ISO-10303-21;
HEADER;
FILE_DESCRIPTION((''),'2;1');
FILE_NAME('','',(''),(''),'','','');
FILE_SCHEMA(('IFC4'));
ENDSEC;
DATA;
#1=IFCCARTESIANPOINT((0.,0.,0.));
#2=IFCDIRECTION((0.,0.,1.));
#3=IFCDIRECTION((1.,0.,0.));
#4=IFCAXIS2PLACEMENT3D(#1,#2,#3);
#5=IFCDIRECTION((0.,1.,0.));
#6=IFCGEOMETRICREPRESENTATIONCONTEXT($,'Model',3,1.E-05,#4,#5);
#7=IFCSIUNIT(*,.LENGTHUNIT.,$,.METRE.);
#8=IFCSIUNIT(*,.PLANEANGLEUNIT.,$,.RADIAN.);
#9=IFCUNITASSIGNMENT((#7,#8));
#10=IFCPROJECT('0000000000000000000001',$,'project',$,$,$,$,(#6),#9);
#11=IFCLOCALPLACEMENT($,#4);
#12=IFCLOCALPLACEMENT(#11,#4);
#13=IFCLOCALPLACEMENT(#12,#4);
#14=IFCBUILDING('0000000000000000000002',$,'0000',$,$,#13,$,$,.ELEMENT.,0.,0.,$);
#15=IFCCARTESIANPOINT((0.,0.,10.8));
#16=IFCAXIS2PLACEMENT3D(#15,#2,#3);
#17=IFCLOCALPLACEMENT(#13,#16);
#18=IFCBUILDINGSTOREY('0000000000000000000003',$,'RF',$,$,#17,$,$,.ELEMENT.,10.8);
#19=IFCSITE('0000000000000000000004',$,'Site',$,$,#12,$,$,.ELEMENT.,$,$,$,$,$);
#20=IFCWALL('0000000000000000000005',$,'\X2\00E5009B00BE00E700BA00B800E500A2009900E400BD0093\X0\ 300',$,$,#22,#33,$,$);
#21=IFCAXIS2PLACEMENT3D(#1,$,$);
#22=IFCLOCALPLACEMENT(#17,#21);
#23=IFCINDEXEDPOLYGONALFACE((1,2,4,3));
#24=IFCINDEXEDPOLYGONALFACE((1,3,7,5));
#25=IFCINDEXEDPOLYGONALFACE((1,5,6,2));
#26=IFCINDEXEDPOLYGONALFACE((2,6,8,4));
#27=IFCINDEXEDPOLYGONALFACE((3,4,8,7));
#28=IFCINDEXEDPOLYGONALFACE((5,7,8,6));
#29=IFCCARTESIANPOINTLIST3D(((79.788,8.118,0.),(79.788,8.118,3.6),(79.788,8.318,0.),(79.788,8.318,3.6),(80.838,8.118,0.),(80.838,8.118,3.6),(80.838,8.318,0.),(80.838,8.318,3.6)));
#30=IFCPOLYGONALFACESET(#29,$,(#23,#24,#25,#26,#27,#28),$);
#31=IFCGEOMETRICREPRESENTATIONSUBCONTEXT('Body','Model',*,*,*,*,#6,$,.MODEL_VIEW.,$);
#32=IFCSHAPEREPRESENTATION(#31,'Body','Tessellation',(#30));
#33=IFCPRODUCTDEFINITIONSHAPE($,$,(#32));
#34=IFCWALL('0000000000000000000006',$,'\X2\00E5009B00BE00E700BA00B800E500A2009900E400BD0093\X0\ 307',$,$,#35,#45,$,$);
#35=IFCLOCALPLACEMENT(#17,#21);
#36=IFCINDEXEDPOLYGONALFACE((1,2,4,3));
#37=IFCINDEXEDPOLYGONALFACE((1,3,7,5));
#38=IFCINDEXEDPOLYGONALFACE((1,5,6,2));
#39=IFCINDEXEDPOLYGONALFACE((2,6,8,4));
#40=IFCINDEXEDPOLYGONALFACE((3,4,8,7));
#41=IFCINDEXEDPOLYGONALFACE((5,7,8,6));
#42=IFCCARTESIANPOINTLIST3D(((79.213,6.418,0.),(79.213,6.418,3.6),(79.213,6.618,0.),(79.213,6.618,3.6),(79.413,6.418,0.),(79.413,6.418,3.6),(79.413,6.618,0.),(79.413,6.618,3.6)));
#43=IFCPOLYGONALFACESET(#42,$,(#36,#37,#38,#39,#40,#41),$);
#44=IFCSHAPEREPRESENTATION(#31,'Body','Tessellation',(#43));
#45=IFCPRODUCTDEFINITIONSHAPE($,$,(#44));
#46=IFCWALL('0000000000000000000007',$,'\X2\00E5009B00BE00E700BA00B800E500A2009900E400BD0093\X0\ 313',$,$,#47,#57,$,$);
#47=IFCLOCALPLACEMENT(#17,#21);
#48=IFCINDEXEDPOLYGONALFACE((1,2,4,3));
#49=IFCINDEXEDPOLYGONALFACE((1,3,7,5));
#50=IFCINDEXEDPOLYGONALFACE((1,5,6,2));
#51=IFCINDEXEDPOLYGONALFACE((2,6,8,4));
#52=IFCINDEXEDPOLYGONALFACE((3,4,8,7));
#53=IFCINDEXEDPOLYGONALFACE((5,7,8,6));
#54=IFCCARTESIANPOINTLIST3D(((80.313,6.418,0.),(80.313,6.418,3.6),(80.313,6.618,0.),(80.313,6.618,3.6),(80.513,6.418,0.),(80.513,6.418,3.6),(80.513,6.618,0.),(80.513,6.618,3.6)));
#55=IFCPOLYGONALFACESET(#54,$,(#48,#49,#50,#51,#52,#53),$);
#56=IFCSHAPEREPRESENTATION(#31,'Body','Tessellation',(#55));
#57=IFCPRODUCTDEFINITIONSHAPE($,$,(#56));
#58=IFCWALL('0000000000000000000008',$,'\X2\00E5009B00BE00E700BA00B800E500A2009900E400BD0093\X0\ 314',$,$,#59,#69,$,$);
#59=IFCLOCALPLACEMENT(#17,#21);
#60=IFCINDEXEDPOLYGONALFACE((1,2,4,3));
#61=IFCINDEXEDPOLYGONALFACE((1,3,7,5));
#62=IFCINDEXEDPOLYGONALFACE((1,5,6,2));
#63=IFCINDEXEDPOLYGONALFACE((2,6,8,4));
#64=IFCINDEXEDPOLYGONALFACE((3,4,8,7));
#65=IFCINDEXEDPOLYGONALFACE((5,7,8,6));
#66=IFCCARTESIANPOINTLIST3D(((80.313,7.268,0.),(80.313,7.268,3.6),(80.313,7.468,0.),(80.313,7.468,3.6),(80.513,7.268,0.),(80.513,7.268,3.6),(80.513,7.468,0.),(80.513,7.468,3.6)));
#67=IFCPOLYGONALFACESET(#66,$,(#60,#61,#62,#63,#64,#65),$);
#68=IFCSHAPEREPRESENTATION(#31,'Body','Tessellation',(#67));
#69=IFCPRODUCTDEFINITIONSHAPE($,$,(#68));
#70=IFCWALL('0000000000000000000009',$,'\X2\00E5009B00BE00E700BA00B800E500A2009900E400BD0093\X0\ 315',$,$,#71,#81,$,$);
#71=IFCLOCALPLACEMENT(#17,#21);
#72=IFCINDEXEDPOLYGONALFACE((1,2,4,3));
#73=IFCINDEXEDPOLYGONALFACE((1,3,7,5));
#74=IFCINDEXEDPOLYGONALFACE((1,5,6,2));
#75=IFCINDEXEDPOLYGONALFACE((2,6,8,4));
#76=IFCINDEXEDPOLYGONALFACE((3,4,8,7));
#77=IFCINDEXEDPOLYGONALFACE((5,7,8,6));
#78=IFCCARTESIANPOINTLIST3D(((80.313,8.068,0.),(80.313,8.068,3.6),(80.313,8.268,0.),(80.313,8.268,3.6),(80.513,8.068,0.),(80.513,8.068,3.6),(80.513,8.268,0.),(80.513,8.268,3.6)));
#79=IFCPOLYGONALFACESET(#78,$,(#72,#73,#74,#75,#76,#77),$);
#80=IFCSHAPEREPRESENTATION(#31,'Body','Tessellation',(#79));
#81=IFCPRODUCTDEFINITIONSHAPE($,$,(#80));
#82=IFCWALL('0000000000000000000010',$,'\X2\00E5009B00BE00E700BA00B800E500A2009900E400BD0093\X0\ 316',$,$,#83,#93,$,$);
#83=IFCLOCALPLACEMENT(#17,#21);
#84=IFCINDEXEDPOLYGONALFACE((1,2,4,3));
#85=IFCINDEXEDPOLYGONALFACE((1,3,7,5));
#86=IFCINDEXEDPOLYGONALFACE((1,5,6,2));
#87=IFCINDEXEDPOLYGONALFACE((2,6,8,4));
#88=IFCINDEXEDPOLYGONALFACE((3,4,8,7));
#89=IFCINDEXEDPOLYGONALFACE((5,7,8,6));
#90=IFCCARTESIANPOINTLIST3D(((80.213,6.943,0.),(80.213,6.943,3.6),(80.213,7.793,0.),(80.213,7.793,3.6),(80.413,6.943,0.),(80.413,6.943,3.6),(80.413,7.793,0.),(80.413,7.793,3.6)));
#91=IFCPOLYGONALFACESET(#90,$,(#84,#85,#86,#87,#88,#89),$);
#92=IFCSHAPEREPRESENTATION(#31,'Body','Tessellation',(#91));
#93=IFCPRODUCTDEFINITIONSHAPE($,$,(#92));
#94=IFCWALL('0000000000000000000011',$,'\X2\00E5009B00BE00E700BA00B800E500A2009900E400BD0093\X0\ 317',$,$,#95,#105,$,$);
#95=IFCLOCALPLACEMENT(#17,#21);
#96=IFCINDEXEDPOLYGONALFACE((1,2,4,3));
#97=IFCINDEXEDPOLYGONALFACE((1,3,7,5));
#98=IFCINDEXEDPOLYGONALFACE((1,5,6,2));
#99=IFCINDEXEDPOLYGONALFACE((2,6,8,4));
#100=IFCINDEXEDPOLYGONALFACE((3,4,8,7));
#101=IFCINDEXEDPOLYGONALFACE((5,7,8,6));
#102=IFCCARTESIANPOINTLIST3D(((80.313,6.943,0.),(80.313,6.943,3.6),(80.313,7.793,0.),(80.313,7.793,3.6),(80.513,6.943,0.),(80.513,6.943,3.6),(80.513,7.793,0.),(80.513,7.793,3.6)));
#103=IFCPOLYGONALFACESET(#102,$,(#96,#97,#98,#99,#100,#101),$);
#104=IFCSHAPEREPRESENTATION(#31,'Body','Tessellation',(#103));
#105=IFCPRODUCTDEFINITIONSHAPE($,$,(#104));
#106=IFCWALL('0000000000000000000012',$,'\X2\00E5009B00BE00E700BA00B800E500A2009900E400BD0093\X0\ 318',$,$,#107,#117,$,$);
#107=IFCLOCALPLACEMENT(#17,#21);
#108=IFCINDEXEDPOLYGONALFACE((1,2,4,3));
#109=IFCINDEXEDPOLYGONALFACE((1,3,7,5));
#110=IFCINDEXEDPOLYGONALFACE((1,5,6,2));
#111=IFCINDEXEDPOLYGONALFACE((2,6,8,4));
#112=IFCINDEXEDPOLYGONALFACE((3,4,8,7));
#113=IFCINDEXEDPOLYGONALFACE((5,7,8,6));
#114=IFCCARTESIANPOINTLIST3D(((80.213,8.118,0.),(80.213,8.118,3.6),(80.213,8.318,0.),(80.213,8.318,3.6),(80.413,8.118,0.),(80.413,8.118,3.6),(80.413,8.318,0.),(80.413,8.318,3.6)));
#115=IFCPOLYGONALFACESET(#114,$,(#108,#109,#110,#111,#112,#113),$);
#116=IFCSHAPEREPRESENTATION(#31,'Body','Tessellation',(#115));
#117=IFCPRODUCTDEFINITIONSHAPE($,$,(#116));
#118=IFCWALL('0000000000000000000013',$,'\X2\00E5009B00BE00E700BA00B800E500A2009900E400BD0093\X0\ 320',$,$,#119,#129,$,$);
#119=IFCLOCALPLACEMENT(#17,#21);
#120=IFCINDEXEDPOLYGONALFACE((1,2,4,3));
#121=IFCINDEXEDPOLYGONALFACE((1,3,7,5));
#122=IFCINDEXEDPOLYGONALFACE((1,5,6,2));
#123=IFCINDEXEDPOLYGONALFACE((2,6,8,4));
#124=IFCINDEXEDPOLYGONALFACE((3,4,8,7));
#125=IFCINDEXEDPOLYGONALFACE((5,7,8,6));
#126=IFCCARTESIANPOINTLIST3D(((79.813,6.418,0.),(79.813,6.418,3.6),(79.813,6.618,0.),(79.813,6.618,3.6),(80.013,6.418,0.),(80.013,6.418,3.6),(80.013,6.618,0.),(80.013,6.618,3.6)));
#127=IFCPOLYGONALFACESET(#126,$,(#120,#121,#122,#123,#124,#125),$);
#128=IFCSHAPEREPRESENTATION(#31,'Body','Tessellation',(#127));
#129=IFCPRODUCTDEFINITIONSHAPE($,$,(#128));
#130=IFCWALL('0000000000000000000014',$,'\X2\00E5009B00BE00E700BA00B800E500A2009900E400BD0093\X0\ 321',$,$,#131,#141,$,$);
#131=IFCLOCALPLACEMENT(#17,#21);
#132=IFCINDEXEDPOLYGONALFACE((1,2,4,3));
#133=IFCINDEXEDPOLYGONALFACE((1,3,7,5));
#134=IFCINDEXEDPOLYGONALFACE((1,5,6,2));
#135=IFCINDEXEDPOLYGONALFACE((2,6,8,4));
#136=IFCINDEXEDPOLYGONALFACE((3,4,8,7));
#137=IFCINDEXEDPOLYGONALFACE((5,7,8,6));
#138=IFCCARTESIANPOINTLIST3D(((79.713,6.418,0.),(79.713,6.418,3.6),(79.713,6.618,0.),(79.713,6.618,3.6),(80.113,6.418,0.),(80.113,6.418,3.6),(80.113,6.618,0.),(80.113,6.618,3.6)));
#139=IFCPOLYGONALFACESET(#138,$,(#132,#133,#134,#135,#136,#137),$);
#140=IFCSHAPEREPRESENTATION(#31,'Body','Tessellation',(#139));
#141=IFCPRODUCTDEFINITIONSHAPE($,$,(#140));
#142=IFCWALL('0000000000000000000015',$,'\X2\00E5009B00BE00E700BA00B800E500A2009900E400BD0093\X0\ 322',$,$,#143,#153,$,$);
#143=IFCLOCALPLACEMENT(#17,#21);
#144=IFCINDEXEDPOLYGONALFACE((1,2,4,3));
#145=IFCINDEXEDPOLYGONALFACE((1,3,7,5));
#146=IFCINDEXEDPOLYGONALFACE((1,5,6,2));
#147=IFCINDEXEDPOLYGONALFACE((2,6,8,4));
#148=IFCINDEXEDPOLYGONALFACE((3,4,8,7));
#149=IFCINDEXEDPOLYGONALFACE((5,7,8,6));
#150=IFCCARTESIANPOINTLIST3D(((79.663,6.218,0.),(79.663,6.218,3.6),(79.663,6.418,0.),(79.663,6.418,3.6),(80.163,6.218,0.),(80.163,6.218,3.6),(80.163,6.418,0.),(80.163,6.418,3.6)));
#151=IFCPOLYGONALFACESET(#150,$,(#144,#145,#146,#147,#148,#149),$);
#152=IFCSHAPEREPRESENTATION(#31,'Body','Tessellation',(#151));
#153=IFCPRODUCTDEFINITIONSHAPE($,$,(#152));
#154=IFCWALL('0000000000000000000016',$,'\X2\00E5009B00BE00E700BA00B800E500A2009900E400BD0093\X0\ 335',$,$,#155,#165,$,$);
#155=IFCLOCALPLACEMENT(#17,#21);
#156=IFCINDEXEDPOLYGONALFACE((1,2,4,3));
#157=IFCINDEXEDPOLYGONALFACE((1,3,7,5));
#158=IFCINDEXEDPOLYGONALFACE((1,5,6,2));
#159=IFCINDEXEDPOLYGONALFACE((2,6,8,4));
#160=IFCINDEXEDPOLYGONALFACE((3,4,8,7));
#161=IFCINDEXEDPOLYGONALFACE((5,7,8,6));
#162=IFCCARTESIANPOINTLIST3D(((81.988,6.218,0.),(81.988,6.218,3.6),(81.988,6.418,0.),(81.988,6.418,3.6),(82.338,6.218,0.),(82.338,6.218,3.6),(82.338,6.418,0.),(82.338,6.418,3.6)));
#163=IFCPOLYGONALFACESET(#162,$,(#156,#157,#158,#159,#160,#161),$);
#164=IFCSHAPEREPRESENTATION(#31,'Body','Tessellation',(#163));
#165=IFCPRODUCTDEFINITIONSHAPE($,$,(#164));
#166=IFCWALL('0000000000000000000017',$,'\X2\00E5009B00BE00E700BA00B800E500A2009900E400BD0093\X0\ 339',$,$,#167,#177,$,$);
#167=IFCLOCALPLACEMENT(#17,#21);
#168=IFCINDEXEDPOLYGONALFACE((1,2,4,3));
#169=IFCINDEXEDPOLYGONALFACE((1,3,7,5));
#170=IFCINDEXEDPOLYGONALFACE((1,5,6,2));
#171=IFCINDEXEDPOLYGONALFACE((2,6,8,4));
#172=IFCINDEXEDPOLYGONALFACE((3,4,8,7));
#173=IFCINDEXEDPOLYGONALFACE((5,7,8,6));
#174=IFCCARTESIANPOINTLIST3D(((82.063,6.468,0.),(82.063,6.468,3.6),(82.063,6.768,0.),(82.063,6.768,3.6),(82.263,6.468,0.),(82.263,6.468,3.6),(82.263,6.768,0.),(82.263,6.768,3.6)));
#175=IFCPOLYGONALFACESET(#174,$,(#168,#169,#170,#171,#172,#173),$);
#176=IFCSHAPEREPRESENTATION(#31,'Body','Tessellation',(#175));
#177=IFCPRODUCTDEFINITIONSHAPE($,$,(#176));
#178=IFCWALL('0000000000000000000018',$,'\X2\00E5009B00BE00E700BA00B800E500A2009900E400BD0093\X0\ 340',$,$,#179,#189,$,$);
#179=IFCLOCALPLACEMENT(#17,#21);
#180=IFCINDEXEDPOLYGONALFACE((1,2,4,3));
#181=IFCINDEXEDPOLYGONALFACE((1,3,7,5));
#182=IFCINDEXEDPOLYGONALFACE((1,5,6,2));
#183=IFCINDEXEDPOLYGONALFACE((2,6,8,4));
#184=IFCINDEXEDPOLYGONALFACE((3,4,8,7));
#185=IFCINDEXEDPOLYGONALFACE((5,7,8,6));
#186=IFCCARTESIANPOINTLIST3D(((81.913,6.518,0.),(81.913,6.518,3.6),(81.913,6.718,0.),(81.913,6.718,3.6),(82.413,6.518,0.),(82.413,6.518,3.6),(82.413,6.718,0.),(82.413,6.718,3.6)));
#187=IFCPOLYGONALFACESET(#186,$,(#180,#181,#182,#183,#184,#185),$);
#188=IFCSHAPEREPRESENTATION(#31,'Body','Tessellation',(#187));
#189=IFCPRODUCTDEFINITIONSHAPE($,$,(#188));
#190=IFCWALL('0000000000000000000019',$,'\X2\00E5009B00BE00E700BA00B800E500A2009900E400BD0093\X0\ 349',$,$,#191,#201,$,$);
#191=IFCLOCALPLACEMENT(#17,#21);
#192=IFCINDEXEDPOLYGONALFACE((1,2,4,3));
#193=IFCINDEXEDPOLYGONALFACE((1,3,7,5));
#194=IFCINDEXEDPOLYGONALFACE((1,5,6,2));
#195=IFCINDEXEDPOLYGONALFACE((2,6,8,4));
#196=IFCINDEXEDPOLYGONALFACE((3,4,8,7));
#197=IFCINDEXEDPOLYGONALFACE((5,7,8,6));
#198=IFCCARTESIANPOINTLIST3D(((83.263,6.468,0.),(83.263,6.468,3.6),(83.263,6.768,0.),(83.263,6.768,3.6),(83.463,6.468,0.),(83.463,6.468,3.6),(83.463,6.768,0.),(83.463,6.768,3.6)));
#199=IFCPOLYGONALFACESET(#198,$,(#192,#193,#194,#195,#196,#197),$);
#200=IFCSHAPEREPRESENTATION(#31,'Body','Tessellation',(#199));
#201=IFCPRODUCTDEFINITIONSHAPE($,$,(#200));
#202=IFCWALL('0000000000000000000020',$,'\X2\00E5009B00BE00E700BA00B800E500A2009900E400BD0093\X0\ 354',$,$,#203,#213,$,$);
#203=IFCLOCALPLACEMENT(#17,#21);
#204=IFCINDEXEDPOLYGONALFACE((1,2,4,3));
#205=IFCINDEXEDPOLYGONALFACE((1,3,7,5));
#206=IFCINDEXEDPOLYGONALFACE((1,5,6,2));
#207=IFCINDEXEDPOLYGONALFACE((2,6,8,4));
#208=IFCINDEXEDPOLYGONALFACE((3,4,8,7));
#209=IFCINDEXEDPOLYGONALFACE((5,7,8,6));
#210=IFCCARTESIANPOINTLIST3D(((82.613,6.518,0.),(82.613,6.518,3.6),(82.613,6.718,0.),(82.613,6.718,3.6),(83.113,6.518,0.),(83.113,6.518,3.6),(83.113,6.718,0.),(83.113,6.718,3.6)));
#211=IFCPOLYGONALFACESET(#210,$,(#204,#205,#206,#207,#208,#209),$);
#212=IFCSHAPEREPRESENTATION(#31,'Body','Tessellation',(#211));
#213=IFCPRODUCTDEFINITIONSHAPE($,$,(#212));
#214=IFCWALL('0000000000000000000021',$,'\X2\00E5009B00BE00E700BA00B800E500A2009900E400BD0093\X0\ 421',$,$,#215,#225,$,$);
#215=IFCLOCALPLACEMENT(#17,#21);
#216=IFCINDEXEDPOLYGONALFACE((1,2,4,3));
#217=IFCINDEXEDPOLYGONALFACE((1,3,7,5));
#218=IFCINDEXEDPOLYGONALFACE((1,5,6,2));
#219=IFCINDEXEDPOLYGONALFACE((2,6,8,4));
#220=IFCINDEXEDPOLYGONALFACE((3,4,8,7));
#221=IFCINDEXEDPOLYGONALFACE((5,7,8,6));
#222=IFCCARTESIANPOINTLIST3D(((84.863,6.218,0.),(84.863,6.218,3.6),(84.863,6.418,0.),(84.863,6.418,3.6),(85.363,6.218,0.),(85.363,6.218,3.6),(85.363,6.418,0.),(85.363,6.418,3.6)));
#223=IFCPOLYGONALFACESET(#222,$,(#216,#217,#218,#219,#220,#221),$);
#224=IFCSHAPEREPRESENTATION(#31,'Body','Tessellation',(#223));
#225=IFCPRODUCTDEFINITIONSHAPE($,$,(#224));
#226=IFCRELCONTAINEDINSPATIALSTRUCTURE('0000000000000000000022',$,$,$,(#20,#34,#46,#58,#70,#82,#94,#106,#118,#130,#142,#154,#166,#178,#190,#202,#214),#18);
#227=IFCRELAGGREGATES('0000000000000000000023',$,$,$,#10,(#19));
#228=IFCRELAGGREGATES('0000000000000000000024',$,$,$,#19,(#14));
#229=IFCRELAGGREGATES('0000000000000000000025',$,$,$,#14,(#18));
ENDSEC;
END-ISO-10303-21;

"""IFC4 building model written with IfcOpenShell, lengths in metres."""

from ifc_helpers import new_model, si_unit, direction, frame, frame_2d, origin_with_axes, place, context, subcontext, project, spatial, rectangle, extrude, element, save


model = new_model("IFC4")

# Units and contexts
model_context = context("Model", 3, precision=1e-05, world=origin_with_axes(), true_north=direction((0.0, 1.0, 0.0)))
body_context = subcontext(model_context, "Body", "Model", "MODEL_VIEW")
ifc_project = project(units=[si_unit("LENGTHUNIT", "METRE"), si_unit("PLANEANGLEUNIT", "RADIAN")], contexts=[model_context])

# Site, building, storey
placement = place(None, origin_with_axes())
site_placement = place(placement, origin_with_axes())
site = spatial("IfcSite", under=ifc_project, at=site_placement, Name="Site", CompositionType="ELEMENT")
building_placement = place(site_placement, origin_with_axes())
building = spatial("IfcBuilding", under=site, at=building_placement, Name="0000", CompositionType="ELEMENT", ElevationOfRefHeight=0.0, ElevationOfTerrain=0.0)
storey_placement = place(building_placement, frame((0.0, 0.0, 10.8), z_axis=(0.0, 0.0, 1.0), x_axis=(1.0, 0.0, 0.0)))
storey = spatial("IfcBuildingStorey", under=building, at=storey_placement, Name="RF", CompositionType="ELEMENT", Elevation=10.8)

# Walls
wall_1_placement = place(storey_placement, frame((80.313, 8.218, 0.0), z_axis=(0.0, 0.0, 1.0), x_axis=(-1.0, 0.0, 0.0)))
element("IfcWall", 1, at=wall_1_placement, inside=storey, Name="å\u009b¾çº¸å¢\u0099ä½\u0093 300", context=body_context, shape_type="SweptSolid", body=[
    extrude(rectangle(XDim=1.05, YDim=0.2, at=frame_2d((0.0, 0.0), x_axis=(1.0, 0.0, 0.0))), frame((0.0, 0.0, 0.0), z_axis=(0.0, 0.0, 1.0)), (0.0, 0.0, 1.0), 3.6),
])
for number, where, z_axis, x_axis, name in (
    (2, (79.313, 6.518, 0.0), (0.0, 0.0, 1.0), (0.0, -1.0, 0.0), "å\u009b¾çº¸å¢\u0099ä½\u0093 307"),
    (3, (80.413, 6.518, 0.0), (0.0, 0.0, 1.0), (0.0, -1.0, 0.0), "å\u009b¾çº¸å¢\u0099ä½\u0093 313"),
    (4, (80.413, 7.368, 0.0), (0.0, 0.0, 1.0), (-1.0, 0.0, 0.0), "å\u009b¾çº¸å¢\u0099ä½\u0093 314"),
    (5, (80.413, 8.168, 0.0), (0.0, 0.0, 1.0), (-1.0, 0.0, 0.0), "å\u009b¾çº¸å¢\u0099ä½\u0093 315"),
):
    element("IfcWall", number, at=place(storey_placement, frame(where, z_axis=z_axis, x_axis=x_axis)), inside=storey, Name=name, context=body_context, shape_type="SweptSolid", body=[
        extrude(rectangle(XDim=0.2, YDim=0.2, at=frame_2d((0.0, 0.0), x_axis=(1.0, 0.0, 0.0))), frame((0.0, 0.0, 0.0), z_axis=(0.0, 0.0, 1.0)), (0.0, 0.0, 1.0), 3.6),
    ])
for number, where, z_axis, x_axis, name in (
    (6, (80.313, 7.368, 0.0), (0.0, 0.0, 1.0), (0.0, -1.0, 0.0), "å\u009b¾çº¸å¢\u0099ä½\u0093 316"),
    (7, (80.413, 7.368, 0.0), (0.0, 0.0, 1.0), (0.0, -1.0, 0.0), "å\u009b¾çº¸å¢\u0099ä½\u0093 317"),
):
    element("IfcWall", number, at=place(storey_placement, frame(where, z_axis=z_axis, x_axis=x_axis)), inside=storey, Name=name, context=body_context, shape_type="SweptSolid", body=[
        extrude(rectangle(XDim=0.85, YDim=0.2, at=frame_2d((0.0, 0.0), x_axis=(1.0, 0.0, 0.0))), frame((0.0, 0.0, 0.0), z_axis=(0.0, 0.0, 1.0)), (0.0, 0.0, 1.0), 3.6),
    ])
for number, where, z_axis, x_axis, name in (
    (8, (80.313, 8.218, 0.0), (0.0, 0.0, 1.0), (0.0, -1.0, 0.0), "å\u009b¾çº¸å¢\u0099ä½\u0093 318"),
    (9, (79.913, 6.518, 0.0), (0.0, 0.0, 1.0), (0.0, -1.0, 0.0), "å\u009b¾çº¸å¢\u0099ä½\u0093 320"),
):
    element("IfcWall", number, at=place(storey_placement, frame(where, z_axis=z_axis, x_axis=x_axis)), inside=storey, Name=name, context=body_context, shape_type="SweptSolid", body=[
        extrude(rectangle(XDim=0.2, YDim=0.2, at=frame_2d((0.0, 0.0), x_axis=(1.0, 0.0, 0.0))), frame((0.0, 0.0, 0.0), z_axis=(0.0, 0.0, 1.0)), (0.0, 0.0, 1.0), 3.6),
    ])
wall_2_placement = place(storey_placement, frame((79.913, 6.518, 0.0), z_axis=(0.0, 0.0, 1.0), x_axis=(1.0, 0.0, 0.0)))
element("IfcWall", 10, at=wall_2_placement, inside=storey, Name="å\u009b¾çº¸å¢\u0099ä½\u0093 321", context=body_context, shape_type="SweptSolid", body=[
    extrude(rectangle(XDim=0.4, YDim=0.2, at=frame_2d((0.0, 0.0), x_axis=(1.0, 0.0, 0.0))), frame((0.0, 0.0, 0.0), z_axis=(0.0, 0.0, 1.0)), (0.0, 0.0, 1.0), 3.6),
])
wall_3_placement = place(storey_placement, frame((79.913, 6.318, 0.0), z_axis=(0.0, 0.0, 1.0), x_axis=(1.0, 0.0, 0.0)))
element("IfcWall", 11, at=wall_3_placement, inside=storey, Name="å\u009b¾çº¸å¢\u0099ä½\u0093 322", context=body_context, shape_type="SweptSolid", body=[
    extrude(rectangle(XDim=0.5, YDim=0.2, at=frame_2d((0.0, 0.0), x_axis=(1.0, 0.0, 0.0))), frame((0.0, 0.0, 0.0), z_axis=(0.0, 0.0, 1.0)), (0.0, 0.0, 1.0), 3.6),
])
wall_4_placement = place(storey_placement, frame((82.163, 6.318, 0.0), z_axis=(0.0, 0.0, 1.0), x_axis=(1.0, 0.0, 0.0)))
element("IfcWall", 12, at=wall_4_placement, inside=storey, Name="å\u009b¾çº¸å¢\u0099ä½\u0093 335", context=body_context, shape_type="SweptSolid", body=[
    extrude(rectangle(XDim=0.35, YDim=0.2, at=frame_2d((0.0, 0.0), x_axis=(1.0, 0.0, 0.0))), frame((0.0, 0.0, 0.0), z_axis=(0.0, 0.0, 1.0)), (0.0, 0.0, 1.0), 3.6),
])
wall_5_placement = place(storey_placement, frame((82.163, 6.618, 0.0), z_axis=(0.0, 0.0, 1.0), x_axis=(0.0, -1.0, 0.0)))
element("IfcWall", 13, at=wall_5_placement, inside=storey, Name="å\u009b¾çº¸å¢\u0099ä½\u0093 339", context=body_context, shape_type="SweptSolid", body=[
    extrude(rectangle(XDim=0.3, YDim=0.2, at=frame_2d((0.0, 0.0), x_axis=(1.0, 0.0, 0.0))), frame((0.0, 0.0, 0.0), z_axis=(0.0, 0.0, 1.0)), (0.0, 0.0, 1.0), 3.6),
])
wall_6_placement = place(storey_placement, frame((82.163, 6.618, 0.0), z_axis=(0.0, 0.0, 1.0), x_axis=(1.0, 0.0, 0.0)))
element("IfcWall", 14, at=wall_6_placement, inside=storey, Name="å\u009b¾çº¸å¢\u0099ä½\u0093 340", context=body_context, shape_type="SweptSolid", body=[
    extrude(rectangle(XDim=0.5, YDim=0.2, at=frame_2d((0.0, 0.0), x_axis=(1.0, 0.0, 0.0))), frame((0.0, 0.0, 0.0), z_axis=(0.0, 0.0, 1.0)), (0.0, 0.0, 1.0), 3.6),
])
wall_7_placement = place(storey_placement, frame((83.363, 6.618, 0.0), z_axis=(0.0, 0.0, 1.0), x_axis=(0.0, -1.0, 0.0)))
element("IfcWall", 15, at=wall_7_placement, inside=storey, Name="å\u009b¾çº¸å¢\u0099ä½\u0093 349", context=body_context, shape_type="SweptSolid", body=[
    extrude(rectangle(XDim=0.3, YDim=0.2, at=frame_2d((0.0, 0.0), x_axis=(1.0, 0.0, 0.0))), frame((0.0, 0.0, 0.0), z_axis=(0.0, 0.0, 1.0)), (0.0, 0.0, 1.0), 3.6),
])
for number, where, z_axis, x_axis, name in (
    (16, (82.863, 6.618, 0.0), (0.0, 0.0, 1.0), (1.0, 0.0, 0.0), "å\u009b¾çº¸å¢\u0099ä½\u0093 354"),
    (17, (85.113, 6.318, 0.0), (0.0, 0.0, 1.0), (1.0, 0.0, 0.0), "å\u009b¾çº¸å¢\u0099ä½\u0093 421"),
):
    element("IfcWall", number, at=place(storey_placement, frame(where, z_axis=z_axis, x_axis=x_axis)), inside=storey, Name=name, context=body_context, shape_type="SweptSolid", body=[
        extrude(rectangle(XDim=0.5, YDim=0.2, at=frame_2d((0.0, 0.0), x_axis=(1.0, 0.0, 0.0))), frame((0.0, 0.0, 0.0), z_axis=(0.0, 0.0, 1.0)), (0.0, 0.0, 1.0), 3.6),
    ])

save(model, "model.ifc")
